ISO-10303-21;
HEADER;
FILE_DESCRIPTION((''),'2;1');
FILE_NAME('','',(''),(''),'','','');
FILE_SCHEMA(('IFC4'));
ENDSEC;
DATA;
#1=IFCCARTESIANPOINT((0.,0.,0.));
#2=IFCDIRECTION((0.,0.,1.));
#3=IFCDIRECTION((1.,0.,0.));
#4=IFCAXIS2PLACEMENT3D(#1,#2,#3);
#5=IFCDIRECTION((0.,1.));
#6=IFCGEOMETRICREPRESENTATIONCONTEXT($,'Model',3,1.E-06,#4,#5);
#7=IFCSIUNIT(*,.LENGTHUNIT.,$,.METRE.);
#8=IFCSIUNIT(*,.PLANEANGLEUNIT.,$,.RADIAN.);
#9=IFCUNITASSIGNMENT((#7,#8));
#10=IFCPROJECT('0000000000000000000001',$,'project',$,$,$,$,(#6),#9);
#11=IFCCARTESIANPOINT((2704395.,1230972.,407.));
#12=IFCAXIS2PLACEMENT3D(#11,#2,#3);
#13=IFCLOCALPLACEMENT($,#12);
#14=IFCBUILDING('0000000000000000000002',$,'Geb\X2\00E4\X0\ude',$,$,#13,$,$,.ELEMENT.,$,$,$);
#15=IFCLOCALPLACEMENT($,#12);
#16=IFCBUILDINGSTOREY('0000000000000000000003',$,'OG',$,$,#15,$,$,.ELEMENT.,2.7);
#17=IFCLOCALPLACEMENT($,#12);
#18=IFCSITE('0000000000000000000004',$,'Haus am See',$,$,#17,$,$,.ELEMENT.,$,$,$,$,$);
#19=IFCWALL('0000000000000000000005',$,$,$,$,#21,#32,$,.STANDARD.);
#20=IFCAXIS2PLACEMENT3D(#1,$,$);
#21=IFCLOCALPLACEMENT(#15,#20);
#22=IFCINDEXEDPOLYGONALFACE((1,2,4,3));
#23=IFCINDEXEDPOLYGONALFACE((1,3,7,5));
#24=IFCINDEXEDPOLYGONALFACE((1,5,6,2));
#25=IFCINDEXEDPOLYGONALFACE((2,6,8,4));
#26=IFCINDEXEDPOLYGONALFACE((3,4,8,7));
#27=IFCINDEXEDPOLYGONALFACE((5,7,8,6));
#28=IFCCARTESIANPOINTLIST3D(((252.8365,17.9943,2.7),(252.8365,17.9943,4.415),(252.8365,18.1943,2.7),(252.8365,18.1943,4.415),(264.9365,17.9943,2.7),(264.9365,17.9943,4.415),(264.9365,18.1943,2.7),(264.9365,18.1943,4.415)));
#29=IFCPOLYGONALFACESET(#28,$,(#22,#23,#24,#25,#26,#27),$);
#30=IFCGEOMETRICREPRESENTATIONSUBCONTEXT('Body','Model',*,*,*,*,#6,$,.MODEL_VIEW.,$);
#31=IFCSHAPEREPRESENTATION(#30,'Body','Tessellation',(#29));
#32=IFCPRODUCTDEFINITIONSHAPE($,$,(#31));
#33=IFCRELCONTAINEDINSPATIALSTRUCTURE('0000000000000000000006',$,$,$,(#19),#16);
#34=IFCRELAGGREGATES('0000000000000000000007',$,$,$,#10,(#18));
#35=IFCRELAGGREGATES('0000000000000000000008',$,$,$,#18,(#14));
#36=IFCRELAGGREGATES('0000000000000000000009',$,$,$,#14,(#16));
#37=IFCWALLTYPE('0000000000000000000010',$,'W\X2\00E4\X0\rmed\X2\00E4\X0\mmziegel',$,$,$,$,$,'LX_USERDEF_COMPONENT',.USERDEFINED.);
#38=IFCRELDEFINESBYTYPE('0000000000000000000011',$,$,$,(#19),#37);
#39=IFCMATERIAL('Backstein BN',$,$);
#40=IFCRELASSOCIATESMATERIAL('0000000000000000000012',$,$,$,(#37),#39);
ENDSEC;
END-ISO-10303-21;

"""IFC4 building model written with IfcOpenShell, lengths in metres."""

from ifc_helpers import new_model, si_unit, direction, frame, origin_with_axes, place, context, subcontext, project, spatial, polyline, outline, extrude, material, type_object, element, save


model = new_model("IFC4")

# Units and contexts
model_context = context("Model", 3, precision=1e-06, world=origin_with_axes(), true_north=direction((0.0, 1.0)))
body_context = subcontext(model_context, "Body", "Model", "MODEL_VIEW")
ifc_project = project(units=[si_unit("LENGTHUNIT", "METRE"), si_unit("PLANEANGLEUNIT", "RADIAN")], contexts=[model_context])

# Site, building, storey
site_placement = place(None, frame((2704395.0, 1230972.0, 407.0), z_axis=(0.0, 0.0, 1.0), x_axis=(1.0, 0.0, 0.0)))
site = spatial("IfcSite", under=ifc_project, at=site_placement, Name="Haus am See", CompositionType="ELEMENT")
building_placement = place(None, frame((2704395.0, 1230972.0, 407.0), z_axis=(0.0, 0.0, 1.0), x_axis=(1.0, 0.0, 0.0)))
building = spatial("IfcBuilding", under=site, at=building_placement, Name="Gebäude", CompositionType="ELEMENT")
storey_placement = place(None, frame((2704395.0, 1230972.0, 407.0), z_axis=(0.0, 0.0, 1.0), x_axis=(1.0, 0.0, 0.0)))
storey = spatial("IfcBuildingStorey", under=building, at=storey_placement, Name="OG", CompositionType="ELEMENT", Elevation=2.7)

# Wall
ifc_material_1 = material(Name="Backstein BN")
wall_type = type_object("IfcWallType", Name="Wärmedämmziegel", ElementType="LX_USERDEF_COMPONENT", PredefinedType="USERDEFINED", material=ifc_material_1)
wall_1_placement = place(storey_placement, frame((264.9365, 18.1943, 2.7), z_axis=(0.0, 0.0, 1.0), x_axis=(-1.0, 0.0, 0.0)))
element("IfcWall", 1, at=wall_1_placement, inside=storey, type_object=wall_type, PredefinedType="STANDARD", context=body_context, shape_type="SweptSolid", body=[
    extrude(outline(polyline([(0.0, 0.0, 0.0), (12.1, 0.0, 0.0), (12.1, 0.2, 0.0), (0.0, 0.2, 0.0), (0.0, 0.0, 0.0)])), origin_with_axes(), (0.0, 0.0, 1.0), 1.715),
])

save(model, "model.ifc")
